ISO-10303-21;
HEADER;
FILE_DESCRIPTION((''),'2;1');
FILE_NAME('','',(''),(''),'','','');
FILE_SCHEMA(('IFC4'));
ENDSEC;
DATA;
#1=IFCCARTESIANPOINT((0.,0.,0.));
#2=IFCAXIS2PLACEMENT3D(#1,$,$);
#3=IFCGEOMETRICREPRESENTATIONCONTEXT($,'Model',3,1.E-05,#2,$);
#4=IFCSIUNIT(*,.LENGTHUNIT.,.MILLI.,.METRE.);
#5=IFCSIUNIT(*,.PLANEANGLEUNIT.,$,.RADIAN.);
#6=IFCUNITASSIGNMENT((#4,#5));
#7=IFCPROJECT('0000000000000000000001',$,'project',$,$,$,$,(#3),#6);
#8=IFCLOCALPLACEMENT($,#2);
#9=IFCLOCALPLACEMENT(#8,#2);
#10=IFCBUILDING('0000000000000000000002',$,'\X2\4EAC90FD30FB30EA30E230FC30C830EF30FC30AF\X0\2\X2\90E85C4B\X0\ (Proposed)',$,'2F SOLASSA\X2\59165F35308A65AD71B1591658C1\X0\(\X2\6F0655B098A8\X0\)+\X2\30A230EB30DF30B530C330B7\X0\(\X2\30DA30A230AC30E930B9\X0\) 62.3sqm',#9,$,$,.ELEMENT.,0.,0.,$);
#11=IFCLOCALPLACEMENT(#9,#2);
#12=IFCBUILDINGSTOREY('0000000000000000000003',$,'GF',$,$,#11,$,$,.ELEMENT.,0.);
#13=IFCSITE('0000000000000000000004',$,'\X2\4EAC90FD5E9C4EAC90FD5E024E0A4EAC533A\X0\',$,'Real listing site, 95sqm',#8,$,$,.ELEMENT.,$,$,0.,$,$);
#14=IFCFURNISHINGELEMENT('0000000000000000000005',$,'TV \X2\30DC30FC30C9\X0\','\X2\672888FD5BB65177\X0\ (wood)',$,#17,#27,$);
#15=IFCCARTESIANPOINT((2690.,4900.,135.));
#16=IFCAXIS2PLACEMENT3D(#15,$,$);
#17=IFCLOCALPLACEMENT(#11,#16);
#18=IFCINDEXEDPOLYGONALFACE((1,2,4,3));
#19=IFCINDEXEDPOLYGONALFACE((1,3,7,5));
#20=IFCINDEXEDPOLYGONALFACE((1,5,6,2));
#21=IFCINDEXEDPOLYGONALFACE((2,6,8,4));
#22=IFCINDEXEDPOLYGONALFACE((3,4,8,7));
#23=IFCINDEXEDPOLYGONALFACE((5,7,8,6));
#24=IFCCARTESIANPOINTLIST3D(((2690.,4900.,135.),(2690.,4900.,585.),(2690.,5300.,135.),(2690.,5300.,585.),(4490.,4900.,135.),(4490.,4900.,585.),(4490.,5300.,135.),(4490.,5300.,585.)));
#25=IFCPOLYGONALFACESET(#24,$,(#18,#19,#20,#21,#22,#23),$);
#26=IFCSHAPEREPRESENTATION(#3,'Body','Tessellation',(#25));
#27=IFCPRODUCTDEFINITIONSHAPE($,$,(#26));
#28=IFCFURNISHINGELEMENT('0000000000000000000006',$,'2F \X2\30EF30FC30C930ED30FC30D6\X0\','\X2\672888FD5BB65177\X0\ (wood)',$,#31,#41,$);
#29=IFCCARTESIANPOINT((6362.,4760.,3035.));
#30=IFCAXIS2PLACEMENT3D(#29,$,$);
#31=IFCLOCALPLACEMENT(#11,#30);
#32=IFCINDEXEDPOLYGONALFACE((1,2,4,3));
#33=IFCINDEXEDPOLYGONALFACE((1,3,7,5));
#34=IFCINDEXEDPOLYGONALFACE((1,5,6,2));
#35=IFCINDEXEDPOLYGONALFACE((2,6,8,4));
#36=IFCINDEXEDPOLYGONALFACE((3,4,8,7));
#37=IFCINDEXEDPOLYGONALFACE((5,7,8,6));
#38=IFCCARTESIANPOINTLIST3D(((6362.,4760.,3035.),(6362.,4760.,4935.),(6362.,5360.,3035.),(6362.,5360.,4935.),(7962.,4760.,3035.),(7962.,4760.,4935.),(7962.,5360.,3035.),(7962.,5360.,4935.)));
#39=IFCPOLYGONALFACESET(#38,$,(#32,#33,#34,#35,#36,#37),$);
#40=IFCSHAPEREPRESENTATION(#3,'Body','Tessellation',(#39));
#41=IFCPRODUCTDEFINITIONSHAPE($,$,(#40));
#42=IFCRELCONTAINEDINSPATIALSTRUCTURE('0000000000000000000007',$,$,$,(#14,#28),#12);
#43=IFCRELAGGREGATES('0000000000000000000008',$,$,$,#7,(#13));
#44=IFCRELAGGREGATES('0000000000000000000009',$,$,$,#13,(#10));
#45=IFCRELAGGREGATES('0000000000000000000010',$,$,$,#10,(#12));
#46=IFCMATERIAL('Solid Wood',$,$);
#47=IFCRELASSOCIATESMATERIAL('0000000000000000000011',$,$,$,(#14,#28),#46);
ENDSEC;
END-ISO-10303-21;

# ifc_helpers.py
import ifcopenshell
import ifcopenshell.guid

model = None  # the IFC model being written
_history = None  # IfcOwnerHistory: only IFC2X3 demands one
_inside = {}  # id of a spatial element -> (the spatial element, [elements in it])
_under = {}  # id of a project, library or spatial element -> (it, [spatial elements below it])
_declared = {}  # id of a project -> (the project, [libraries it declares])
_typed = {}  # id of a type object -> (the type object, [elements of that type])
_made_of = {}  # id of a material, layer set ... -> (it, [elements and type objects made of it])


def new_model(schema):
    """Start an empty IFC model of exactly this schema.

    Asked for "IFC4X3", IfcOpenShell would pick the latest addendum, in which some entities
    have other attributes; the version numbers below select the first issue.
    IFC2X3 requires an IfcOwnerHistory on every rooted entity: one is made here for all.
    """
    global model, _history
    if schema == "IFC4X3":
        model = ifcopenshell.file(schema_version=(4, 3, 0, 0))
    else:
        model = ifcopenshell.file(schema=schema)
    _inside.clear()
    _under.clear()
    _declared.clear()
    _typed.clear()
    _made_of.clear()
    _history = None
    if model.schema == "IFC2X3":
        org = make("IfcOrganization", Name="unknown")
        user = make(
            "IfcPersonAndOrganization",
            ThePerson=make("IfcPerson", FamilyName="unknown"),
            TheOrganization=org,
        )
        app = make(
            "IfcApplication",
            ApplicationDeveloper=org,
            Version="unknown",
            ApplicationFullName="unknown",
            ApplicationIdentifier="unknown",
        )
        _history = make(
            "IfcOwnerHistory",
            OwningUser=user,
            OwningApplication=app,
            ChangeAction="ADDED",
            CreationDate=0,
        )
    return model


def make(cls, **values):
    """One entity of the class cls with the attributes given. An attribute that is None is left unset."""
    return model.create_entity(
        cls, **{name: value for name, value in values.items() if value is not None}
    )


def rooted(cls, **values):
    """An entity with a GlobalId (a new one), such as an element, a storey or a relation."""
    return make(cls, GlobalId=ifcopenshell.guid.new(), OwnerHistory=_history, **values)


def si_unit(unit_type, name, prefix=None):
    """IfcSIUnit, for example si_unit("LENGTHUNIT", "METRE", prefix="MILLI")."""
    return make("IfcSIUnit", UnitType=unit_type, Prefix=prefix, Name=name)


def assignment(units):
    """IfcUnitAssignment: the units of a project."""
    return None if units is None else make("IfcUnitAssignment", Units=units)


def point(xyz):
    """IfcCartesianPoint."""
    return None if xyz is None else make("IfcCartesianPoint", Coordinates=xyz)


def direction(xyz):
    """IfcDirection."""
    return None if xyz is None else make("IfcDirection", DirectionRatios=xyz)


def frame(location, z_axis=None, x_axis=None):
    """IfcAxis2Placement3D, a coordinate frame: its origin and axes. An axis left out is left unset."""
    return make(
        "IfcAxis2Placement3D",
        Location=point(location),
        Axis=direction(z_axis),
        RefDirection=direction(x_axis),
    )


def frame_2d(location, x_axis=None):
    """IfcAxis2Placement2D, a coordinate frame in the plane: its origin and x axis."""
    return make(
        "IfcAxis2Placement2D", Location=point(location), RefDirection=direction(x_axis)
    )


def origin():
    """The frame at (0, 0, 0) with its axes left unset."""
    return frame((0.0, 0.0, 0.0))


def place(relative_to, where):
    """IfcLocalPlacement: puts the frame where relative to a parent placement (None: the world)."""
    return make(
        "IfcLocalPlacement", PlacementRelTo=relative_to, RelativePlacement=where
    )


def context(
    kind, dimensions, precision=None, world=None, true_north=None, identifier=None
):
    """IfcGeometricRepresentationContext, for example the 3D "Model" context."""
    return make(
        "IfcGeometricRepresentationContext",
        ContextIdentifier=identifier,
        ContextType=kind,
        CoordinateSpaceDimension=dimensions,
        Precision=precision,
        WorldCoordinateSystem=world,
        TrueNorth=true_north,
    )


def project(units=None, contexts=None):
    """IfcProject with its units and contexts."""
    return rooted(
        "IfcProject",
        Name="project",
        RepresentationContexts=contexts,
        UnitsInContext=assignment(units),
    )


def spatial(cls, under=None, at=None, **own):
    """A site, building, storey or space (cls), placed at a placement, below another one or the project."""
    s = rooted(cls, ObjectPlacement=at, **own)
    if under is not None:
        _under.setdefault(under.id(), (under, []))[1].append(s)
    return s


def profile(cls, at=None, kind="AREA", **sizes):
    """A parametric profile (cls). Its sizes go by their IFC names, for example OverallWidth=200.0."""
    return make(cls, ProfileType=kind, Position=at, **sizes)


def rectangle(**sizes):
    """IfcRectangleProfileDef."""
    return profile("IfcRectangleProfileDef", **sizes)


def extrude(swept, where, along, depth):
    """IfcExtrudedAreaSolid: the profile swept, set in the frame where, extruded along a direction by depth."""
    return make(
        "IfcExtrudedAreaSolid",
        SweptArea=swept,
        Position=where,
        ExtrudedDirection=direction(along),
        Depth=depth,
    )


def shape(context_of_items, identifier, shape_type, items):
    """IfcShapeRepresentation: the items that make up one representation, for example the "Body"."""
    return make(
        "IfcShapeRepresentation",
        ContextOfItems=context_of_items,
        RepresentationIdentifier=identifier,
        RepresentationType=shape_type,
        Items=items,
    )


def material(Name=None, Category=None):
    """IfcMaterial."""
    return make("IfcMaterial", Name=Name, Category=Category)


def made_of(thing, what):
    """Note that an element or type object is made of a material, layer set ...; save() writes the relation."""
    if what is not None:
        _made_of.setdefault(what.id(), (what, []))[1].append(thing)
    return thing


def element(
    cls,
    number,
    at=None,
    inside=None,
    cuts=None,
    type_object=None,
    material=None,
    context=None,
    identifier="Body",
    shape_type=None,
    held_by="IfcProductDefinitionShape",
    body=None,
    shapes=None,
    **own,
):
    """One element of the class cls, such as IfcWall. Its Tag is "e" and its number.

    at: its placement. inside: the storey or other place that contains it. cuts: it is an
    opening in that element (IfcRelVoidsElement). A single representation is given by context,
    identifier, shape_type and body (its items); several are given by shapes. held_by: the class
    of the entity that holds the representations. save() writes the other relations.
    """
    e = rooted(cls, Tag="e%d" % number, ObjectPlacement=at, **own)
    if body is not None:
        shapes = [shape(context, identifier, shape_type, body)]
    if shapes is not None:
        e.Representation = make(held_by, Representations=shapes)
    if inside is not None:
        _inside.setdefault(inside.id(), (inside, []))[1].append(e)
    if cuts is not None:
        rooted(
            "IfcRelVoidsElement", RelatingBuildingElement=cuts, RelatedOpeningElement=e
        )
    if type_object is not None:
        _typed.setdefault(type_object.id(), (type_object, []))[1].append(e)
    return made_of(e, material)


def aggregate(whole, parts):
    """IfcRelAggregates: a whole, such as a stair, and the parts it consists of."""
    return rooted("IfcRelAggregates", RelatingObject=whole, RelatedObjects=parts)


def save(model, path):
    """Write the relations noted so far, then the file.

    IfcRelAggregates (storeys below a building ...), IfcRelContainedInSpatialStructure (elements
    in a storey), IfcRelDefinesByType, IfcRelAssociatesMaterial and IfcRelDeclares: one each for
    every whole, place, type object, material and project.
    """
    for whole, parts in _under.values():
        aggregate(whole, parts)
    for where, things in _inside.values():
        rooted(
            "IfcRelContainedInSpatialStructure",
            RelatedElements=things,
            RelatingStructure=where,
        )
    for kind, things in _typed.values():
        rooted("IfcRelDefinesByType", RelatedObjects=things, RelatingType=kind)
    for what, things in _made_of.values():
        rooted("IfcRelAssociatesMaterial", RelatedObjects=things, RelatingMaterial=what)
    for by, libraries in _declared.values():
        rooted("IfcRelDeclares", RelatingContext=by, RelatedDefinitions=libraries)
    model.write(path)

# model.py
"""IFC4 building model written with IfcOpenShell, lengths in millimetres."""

from ifc_helpers import new_model, si_unit, frame, frame_2d, origin, place, context, project, spatial, rectangle, extrude, material, element, save


model = new_model("IFC4")

# Units and contexts
model_context = context("Model", 3, precision=1e-05, world=origin())
ifc_project = project(units=[si_unit("LENGTHUNIT", "METRE", prefix="MILLI"), si_unit("PLANEANGLEUNIT", "RADIAN")], contexts=[model_context])

# Site, building, storey
site_placement = place(None, origin())
site = spatial("IfcSite", under=ifc_project, at=site_placement, Name="京都府京都市上京区", ObjectType="Real listing site, 95sqm", CompositionType="ELEMENT", RefElevation=0.0)
building_placement = place(site_placement, origin())
building = spatial("IfcBuilding", under=site, at=building_placement, Name="京都・リモートワーク2部屋 (Proposed)", ObjectType="2F SOLASSA外張り断熱外壁(漆喰風)+アルミサッシ(ペアガラス) 62.3sqm", CompositionType="ELEMENT", ElevationOfRefHeight=0.0, ElevationOfTerrain=0.0)
storey_placement = place(building_placement, origin())
storey = spatial("IfcBuildingStorey", under=building, at=storey_placement, Name="GF", CompositionType="ELEMENT", Elevation=0.0)

# Shared definitions
ifc_material_1 = material(Name="Solid Wood")

# Furnishing elements
furnishing_1_placement = place(storey_placement, frame((2690.0, 4900.0, 135.0)))
element("IfcFurnishingElement", 1, at=furnishing_1_placement, inside=storey, material=ifc_material_1, Name="TV ボード", Description="木製家具 (wood)", context=model_context, shape_type="SweptSolid", body=[
    extrude(rectangle(XDim=1800.0, YDim=400.0, at=frame_2d((900.0, 200.0))), frame((2690.0, 4900.0, 135.0)), (0.0, 0.0, 1.0), 450.0),
])
furnishing_2_placement = place(storey_placement, frame((6362.0, 4760.0, 3035.0)))
element("IfcFurnishingElement", 2, at=furnishing_2_placement, inside=storey, material=ifc_material_1, Name="2F ワードローブ", Description="木製家具 (wood)", context=model_context, shape_type="SweptSolid", body=[
    extrude(rectangle(XDim=1600.0, YDim=600.0, at=frame_2d((800.0, 300.0))), frame((6362.0, 4760.0, 3035.0)), (0.0, 0.0, 1.0), 1900.0),
])

save(model, "model.ifc")
